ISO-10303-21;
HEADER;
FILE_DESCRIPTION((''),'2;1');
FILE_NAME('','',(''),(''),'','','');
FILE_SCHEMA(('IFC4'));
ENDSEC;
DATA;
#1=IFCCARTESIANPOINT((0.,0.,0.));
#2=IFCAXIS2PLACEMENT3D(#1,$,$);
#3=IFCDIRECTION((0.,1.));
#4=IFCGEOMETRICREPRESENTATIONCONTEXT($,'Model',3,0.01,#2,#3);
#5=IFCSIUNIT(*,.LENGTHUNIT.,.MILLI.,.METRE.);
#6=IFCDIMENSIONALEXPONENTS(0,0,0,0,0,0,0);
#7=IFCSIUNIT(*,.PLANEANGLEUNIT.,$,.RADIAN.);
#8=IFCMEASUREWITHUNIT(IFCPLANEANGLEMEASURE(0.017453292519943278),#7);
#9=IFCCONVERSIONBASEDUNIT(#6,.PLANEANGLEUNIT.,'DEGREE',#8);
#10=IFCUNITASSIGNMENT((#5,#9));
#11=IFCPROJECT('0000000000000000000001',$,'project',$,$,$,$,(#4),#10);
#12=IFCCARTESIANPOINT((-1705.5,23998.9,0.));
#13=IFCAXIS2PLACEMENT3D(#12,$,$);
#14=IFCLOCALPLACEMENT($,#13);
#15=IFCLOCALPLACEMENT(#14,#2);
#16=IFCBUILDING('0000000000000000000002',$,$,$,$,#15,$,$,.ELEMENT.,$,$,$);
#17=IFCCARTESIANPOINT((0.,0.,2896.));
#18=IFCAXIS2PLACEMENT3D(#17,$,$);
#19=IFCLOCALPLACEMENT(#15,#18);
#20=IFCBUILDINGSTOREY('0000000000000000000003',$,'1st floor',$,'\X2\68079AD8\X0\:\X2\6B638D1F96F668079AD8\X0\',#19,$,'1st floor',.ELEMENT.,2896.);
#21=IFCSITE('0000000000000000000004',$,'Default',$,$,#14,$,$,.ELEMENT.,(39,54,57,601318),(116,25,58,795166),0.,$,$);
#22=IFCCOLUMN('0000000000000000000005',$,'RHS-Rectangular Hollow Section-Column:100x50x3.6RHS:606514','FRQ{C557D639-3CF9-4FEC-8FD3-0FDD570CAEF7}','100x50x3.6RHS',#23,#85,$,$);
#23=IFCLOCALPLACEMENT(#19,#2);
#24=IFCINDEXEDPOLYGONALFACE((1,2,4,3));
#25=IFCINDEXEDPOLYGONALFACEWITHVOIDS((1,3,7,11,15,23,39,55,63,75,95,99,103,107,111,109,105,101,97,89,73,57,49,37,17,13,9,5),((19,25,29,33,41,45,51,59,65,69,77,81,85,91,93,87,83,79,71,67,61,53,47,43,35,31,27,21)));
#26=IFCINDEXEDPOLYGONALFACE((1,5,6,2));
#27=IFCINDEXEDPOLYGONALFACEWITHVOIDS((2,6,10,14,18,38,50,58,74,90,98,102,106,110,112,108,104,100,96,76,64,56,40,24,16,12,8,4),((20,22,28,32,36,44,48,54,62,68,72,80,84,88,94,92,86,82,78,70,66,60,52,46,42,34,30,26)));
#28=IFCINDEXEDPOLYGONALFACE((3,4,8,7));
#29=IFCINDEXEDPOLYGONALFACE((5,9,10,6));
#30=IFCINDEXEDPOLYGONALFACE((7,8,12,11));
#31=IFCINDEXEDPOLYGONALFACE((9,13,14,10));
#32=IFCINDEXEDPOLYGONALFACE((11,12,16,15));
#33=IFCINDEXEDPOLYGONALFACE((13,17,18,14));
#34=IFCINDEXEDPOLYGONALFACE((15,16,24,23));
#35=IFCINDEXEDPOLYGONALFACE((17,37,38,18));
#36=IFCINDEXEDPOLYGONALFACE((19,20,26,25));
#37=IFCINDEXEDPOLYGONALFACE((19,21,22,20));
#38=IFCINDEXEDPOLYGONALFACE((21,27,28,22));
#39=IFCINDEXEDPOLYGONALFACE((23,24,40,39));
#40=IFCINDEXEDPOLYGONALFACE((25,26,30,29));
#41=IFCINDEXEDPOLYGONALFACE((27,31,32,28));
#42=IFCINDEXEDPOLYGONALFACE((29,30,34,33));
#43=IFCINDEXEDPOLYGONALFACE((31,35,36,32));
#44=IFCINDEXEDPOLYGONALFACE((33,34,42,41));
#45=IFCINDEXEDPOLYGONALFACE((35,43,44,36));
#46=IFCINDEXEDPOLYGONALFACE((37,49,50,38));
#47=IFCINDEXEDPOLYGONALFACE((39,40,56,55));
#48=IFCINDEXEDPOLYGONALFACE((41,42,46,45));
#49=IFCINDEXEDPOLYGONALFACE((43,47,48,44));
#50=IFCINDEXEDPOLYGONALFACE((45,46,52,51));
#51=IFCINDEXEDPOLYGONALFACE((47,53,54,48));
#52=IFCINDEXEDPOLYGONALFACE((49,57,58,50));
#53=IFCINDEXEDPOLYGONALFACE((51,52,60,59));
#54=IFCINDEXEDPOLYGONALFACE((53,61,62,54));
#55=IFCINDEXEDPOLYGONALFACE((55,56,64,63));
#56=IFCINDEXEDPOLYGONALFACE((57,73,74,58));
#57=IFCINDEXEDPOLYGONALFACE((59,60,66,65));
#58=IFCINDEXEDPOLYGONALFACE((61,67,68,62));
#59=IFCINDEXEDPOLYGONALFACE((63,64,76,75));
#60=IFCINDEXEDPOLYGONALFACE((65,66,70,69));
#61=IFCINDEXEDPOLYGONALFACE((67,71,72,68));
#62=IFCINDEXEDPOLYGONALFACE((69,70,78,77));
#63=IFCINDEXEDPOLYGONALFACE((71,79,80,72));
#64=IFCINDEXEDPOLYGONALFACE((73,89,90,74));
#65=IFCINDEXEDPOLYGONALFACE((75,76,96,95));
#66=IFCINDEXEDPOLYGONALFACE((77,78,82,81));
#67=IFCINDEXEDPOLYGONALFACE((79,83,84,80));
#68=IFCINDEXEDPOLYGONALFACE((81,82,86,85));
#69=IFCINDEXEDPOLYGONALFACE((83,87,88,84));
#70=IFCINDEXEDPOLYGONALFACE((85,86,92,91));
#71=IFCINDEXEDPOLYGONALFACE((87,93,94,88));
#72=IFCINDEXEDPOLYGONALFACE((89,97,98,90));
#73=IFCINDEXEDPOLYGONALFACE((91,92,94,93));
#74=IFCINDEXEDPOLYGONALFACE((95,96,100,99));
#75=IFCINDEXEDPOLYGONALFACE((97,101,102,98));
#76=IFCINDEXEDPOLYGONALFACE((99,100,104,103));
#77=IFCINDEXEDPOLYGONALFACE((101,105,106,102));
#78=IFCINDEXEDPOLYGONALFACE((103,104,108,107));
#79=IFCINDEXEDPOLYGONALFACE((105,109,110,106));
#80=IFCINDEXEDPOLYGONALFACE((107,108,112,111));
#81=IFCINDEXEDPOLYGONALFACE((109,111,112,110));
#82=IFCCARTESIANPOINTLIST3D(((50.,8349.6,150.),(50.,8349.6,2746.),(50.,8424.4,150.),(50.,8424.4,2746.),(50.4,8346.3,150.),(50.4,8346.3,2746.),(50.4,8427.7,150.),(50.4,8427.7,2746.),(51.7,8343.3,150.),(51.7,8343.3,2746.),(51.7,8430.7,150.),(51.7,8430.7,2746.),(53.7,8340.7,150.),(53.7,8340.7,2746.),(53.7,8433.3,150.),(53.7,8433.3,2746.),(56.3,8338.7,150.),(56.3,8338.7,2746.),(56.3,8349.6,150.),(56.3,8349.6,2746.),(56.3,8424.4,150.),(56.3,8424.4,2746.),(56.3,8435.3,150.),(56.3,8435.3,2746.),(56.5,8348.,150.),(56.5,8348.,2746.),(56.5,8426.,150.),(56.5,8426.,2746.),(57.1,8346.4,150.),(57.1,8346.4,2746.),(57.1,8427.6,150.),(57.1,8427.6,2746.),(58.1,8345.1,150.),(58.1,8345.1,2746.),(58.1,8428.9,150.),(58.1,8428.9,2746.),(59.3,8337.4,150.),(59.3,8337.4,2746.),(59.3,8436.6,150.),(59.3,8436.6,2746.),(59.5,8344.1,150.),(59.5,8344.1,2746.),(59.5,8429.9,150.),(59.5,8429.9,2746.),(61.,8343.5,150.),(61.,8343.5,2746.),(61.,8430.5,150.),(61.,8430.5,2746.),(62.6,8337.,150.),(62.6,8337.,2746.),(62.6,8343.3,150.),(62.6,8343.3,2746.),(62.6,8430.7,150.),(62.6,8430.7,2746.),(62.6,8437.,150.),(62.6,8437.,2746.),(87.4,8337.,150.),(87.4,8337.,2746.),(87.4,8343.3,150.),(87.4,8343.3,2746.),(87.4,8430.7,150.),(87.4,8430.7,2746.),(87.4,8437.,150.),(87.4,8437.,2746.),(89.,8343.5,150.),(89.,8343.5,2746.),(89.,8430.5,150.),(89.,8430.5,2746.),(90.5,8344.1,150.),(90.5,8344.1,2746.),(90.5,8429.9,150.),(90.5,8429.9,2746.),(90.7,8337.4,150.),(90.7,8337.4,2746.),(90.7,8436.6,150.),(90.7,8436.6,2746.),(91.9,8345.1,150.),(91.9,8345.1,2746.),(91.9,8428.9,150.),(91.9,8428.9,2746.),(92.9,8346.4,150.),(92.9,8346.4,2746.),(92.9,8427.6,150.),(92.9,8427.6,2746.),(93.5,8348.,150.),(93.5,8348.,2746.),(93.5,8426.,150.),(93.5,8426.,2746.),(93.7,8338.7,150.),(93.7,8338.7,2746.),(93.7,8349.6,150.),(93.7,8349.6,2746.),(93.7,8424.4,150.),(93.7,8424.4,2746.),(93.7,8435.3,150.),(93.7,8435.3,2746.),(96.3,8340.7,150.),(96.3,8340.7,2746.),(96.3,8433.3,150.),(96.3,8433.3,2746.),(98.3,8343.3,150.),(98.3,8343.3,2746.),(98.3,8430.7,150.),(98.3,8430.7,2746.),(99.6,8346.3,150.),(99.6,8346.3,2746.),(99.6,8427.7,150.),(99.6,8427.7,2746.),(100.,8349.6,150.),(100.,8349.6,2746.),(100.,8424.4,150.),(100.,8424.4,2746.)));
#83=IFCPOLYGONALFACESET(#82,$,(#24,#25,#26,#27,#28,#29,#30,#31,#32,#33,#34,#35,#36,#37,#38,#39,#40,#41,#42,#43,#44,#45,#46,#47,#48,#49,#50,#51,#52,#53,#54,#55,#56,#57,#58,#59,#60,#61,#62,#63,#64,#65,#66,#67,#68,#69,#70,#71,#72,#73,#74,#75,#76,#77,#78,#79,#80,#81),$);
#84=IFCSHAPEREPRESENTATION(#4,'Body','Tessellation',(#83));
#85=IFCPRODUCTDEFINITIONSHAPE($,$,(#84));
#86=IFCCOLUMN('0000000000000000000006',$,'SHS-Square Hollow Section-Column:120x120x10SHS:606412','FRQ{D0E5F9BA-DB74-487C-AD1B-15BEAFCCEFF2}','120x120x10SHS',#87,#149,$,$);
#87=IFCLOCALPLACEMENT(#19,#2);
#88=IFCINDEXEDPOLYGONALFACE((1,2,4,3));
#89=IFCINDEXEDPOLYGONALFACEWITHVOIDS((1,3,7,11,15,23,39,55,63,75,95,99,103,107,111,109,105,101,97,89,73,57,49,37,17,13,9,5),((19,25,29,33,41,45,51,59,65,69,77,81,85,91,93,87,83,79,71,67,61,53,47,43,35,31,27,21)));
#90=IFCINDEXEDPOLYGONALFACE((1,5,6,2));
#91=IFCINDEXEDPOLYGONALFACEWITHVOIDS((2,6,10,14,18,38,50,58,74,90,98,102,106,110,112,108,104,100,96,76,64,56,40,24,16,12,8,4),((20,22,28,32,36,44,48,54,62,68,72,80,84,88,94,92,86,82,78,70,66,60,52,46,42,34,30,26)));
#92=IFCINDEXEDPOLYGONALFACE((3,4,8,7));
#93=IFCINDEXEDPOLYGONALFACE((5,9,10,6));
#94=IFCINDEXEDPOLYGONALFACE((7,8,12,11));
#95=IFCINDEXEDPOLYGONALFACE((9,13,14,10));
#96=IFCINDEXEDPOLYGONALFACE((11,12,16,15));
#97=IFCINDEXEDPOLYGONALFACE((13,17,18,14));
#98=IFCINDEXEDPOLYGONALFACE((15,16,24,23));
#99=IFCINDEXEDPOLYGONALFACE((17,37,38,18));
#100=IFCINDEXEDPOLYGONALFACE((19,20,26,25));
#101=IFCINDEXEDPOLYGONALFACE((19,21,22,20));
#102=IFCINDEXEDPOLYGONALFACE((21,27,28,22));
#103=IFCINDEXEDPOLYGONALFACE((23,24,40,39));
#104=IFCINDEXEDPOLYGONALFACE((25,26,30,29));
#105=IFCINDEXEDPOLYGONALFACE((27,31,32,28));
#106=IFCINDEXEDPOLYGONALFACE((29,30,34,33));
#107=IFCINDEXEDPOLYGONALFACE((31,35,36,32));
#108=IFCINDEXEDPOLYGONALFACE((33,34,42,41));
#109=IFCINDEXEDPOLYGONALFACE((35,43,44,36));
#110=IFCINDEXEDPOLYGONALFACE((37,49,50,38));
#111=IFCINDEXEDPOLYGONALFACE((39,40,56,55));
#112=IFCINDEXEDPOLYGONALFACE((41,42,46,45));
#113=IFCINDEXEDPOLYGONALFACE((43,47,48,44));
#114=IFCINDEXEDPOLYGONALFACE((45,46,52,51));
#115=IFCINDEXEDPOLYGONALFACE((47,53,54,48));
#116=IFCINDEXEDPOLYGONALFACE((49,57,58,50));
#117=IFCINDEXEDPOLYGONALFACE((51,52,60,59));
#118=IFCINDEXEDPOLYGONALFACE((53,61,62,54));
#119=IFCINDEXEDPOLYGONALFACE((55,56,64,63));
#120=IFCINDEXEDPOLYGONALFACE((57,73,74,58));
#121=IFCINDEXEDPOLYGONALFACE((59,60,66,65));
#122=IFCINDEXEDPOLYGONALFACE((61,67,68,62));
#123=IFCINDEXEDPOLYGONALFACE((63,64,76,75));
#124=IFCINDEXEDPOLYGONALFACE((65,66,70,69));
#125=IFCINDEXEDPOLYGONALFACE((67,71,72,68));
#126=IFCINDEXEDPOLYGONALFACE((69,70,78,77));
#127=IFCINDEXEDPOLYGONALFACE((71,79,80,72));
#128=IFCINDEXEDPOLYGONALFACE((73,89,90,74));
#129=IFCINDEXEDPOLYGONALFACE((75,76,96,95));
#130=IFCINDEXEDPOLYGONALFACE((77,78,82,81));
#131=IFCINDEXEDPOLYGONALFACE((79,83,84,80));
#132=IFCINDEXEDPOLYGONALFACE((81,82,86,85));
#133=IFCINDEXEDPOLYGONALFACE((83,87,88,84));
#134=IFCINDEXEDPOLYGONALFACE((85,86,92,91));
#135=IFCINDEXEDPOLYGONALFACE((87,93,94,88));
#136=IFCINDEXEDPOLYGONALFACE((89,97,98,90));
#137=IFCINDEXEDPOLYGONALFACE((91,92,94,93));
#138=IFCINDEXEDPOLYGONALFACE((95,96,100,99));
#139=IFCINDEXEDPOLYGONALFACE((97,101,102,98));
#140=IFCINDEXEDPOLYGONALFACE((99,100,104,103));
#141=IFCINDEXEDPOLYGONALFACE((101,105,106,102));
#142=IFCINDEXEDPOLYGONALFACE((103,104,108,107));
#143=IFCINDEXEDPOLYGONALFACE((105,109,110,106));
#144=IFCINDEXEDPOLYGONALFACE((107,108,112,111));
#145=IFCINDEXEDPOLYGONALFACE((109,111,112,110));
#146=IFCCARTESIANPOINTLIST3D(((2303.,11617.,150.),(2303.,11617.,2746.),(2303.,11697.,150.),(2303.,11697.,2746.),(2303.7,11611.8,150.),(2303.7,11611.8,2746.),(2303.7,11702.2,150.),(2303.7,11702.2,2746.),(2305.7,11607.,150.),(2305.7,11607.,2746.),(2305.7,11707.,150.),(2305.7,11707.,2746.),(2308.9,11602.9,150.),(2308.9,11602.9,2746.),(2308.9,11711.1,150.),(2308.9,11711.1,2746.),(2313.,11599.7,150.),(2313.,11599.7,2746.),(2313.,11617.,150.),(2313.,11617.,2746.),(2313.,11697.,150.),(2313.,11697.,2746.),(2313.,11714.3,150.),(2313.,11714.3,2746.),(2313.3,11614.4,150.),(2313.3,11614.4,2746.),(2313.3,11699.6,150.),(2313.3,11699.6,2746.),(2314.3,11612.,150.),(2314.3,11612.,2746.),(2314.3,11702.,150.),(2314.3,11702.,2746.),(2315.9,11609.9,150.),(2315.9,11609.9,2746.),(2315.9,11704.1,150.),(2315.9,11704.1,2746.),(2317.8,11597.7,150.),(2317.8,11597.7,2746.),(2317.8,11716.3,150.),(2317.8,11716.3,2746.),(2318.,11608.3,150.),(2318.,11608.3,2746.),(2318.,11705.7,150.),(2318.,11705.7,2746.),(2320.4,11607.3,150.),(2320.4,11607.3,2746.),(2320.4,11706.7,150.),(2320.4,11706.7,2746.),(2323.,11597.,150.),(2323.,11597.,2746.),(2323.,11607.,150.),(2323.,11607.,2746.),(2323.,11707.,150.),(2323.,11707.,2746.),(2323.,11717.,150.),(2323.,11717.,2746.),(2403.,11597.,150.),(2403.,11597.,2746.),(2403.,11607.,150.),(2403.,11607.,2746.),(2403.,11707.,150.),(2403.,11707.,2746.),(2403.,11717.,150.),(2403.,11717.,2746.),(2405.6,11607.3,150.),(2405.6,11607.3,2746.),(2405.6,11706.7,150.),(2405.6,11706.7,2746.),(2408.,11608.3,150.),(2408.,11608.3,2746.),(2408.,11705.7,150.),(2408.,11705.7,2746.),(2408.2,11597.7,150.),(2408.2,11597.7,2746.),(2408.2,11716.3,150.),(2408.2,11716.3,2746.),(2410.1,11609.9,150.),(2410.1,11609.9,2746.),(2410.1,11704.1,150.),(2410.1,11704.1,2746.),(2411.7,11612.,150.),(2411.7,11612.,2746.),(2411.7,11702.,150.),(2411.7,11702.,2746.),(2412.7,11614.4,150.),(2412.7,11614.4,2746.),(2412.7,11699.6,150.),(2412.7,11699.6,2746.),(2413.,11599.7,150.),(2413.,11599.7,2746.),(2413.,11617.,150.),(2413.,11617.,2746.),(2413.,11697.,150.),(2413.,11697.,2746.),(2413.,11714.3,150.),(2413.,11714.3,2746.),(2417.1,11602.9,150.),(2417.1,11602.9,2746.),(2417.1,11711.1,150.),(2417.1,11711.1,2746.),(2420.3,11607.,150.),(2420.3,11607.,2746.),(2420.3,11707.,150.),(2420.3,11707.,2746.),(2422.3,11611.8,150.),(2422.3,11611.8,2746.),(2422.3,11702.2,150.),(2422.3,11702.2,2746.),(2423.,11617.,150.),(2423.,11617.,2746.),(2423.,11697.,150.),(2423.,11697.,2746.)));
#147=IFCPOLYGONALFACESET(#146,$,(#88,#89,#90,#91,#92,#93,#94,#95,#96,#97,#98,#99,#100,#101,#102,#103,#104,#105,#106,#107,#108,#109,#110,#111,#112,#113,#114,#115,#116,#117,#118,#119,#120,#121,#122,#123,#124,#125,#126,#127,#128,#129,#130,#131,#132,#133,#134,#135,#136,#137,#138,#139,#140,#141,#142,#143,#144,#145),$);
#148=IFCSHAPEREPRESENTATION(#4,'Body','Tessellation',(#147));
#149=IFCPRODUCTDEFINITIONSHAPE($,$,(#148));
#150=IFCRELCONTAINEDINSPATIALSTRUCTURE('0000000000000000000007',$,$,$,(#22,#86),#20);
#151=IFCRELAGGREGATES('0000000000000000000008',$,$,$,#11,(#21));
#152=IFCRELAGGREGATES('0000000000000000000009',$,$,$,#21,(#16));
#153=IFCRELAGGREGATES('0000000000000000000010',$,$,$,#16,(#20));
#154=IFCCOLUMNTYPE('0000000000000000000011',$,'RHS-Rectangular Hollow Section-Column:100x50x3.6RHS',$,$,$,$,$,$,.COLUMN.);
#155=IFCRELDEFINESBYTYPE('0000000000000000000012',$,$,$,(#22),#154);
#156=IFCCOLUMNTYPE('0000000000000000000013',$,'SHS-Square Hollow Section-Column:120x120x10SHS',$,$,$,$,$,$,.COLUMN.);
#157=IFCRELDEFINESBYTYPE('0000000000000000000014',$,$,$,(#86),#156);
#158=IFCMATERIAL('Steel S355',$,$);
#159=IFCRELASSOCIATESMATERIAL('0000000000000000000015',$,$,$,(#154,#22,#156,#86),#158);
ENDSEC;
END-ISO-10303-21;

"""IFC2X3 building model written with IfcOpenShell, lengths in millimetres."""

from ifc_helpers import new_model, entity, si_unit, converted_unit, direction, frame, origin, origin_2d, place, context, project, spatial, hollow_rectangle, extrude, clip, halfspace, material, type_object, element, save


model = new_model("IFC2X3")

# Units and contexts
model_context = context("Model", 3, precision=0.01, world=origin(), true_north=direction((0.0, 1.0)))
ifc_project = project(units=[si_unit("LENGTHUNIT", "METRE", prefix="MILLI"), converted_unit("PLANEANGLEUNIT", "DEGREE", entity("IfcPlaneAngleMeasure", 0.017453292519943278), si_unit("PLANEANGLEUNIT", "RADIAN"), dimensions=[0, 0, 0, 0, 0, 0, 0])], contexts=[model_context])

# Site, building, storey
site_placement = place(None, frame((-1705.5, 23998.9, 0.0)))
site = spatial("IfcSite", under=ifc_project, at=site_placement, Name="Default", CompositionType="ELEMENT", RefLatitude=(39, 54, 57, 601318), RefLongitude=(116, 25, 58, 795166), RefElevation=0.0)
building_placement = place(site_placement, origin())
building = spatial("IfcBuilding", under=site, at=building_placement, CompositionType="ELEMENT")
storey_placement = place(building_placement, frame((0.0, 0.0, 2896.0)))
storey = spatial("IfcBuildingStorey", under=building, at=storey_placement, Name="1st floor", ObjectType="标高:正负零标高", LongName="1st floor", CompositionType="ELEMENT", Elevation=2896.0)

# Shared definitions
ifc_material_1 = material(Name="Steel S355")

# Columns
column_type_1 = type_object("IfcColumnType", Name="RHS-Rectangular Hollow Section-Column:100x50x3.6RHS", PredefinedType="COLUMN", material=ifc_material_1)
column_1_placement = place(storey_placement, frame((75.0, 8387.0, 2746.0), z_axis=(0.0, 0.0, 1.0), x_axis=(-1.0, 0.0, 0.0)))
element("IfcColumn", 1, at=column_1_placement, inside=storey, type_object=column_type_1, material=ifc_material_1, Name="RHS-Rectangular Hollow Section-Column:100x50x3.6RHS:606514", Description="FRQ{C557D639-3CF9-4FEC-8FD3-0FDD570CAEF7}", ObjectType="100x50x3.6RHS", context=model_context, shape_type="Clipping", body=[
    clip(extrude(hollow_rectangle(XDim=50.0, YDim=100.0, WallThickness=6.3, InnerFilletRadius=6.3, OuterFilletRadius=12.6, at=origin_2d()), origin(), (0.0, 0.0, -1.0), 2651.9), halfspace(frame((75.0, 8387.0, -2596.0), z_axis=(0.0, 0.0, 1.0), x_axis=(-1.0, 0.0, 0.0)), True)),
])
column_type_2 = type_object("IfcColumnType", Name="SHS-Square Hollow Section-Column:120x120x10SHS", PredefinedType="COLUMN", material=ifc_material_1)
column_2_placement = place(storey_placement, frame((2363.0, 11657.0, 2830.9), z_axis=(0.0, 0.0, 1.0), x_axis=(0.0, -1.0, 0.0)))
element("IfcColumn", 2, at=column_2_placement, inside=storey, type_object=column_type_2, material=ifc_material_1, Name="SHS-Square Hollow Section-Column:120x120x10SHS:606412", Description="FRQ{D0E5F9BA-DB74-487C-AD1B-15BEAFCCEFF2}", ObjectType="120x120x10SHS", context=model_context, shape_type="Clipping", body=[
    clip(clip(extrude(hollow_rectangle(XDim=120.0, YDim=120.0, WallThickness=10.0, InnerFilletRadius=10.0, OuterFilletRadius=20.0, at=origin_2d()), origin(), (0.0, 0.0, -1.0), 2765.7), halfspace(frame((11657.0, -2363.0, -84.9), z_axis=(0.0, 0.0, -1.0), x_axis=(0.0, -1.0, 0.0)), True)), halfspace(frame((11657.0, -2363.0, -2680.9), z_axis=(0.0, 0.0, 1.0), x_axis=(0.0, 1.0, 0.0)), True)),
])

save(model, "model.ifc")
